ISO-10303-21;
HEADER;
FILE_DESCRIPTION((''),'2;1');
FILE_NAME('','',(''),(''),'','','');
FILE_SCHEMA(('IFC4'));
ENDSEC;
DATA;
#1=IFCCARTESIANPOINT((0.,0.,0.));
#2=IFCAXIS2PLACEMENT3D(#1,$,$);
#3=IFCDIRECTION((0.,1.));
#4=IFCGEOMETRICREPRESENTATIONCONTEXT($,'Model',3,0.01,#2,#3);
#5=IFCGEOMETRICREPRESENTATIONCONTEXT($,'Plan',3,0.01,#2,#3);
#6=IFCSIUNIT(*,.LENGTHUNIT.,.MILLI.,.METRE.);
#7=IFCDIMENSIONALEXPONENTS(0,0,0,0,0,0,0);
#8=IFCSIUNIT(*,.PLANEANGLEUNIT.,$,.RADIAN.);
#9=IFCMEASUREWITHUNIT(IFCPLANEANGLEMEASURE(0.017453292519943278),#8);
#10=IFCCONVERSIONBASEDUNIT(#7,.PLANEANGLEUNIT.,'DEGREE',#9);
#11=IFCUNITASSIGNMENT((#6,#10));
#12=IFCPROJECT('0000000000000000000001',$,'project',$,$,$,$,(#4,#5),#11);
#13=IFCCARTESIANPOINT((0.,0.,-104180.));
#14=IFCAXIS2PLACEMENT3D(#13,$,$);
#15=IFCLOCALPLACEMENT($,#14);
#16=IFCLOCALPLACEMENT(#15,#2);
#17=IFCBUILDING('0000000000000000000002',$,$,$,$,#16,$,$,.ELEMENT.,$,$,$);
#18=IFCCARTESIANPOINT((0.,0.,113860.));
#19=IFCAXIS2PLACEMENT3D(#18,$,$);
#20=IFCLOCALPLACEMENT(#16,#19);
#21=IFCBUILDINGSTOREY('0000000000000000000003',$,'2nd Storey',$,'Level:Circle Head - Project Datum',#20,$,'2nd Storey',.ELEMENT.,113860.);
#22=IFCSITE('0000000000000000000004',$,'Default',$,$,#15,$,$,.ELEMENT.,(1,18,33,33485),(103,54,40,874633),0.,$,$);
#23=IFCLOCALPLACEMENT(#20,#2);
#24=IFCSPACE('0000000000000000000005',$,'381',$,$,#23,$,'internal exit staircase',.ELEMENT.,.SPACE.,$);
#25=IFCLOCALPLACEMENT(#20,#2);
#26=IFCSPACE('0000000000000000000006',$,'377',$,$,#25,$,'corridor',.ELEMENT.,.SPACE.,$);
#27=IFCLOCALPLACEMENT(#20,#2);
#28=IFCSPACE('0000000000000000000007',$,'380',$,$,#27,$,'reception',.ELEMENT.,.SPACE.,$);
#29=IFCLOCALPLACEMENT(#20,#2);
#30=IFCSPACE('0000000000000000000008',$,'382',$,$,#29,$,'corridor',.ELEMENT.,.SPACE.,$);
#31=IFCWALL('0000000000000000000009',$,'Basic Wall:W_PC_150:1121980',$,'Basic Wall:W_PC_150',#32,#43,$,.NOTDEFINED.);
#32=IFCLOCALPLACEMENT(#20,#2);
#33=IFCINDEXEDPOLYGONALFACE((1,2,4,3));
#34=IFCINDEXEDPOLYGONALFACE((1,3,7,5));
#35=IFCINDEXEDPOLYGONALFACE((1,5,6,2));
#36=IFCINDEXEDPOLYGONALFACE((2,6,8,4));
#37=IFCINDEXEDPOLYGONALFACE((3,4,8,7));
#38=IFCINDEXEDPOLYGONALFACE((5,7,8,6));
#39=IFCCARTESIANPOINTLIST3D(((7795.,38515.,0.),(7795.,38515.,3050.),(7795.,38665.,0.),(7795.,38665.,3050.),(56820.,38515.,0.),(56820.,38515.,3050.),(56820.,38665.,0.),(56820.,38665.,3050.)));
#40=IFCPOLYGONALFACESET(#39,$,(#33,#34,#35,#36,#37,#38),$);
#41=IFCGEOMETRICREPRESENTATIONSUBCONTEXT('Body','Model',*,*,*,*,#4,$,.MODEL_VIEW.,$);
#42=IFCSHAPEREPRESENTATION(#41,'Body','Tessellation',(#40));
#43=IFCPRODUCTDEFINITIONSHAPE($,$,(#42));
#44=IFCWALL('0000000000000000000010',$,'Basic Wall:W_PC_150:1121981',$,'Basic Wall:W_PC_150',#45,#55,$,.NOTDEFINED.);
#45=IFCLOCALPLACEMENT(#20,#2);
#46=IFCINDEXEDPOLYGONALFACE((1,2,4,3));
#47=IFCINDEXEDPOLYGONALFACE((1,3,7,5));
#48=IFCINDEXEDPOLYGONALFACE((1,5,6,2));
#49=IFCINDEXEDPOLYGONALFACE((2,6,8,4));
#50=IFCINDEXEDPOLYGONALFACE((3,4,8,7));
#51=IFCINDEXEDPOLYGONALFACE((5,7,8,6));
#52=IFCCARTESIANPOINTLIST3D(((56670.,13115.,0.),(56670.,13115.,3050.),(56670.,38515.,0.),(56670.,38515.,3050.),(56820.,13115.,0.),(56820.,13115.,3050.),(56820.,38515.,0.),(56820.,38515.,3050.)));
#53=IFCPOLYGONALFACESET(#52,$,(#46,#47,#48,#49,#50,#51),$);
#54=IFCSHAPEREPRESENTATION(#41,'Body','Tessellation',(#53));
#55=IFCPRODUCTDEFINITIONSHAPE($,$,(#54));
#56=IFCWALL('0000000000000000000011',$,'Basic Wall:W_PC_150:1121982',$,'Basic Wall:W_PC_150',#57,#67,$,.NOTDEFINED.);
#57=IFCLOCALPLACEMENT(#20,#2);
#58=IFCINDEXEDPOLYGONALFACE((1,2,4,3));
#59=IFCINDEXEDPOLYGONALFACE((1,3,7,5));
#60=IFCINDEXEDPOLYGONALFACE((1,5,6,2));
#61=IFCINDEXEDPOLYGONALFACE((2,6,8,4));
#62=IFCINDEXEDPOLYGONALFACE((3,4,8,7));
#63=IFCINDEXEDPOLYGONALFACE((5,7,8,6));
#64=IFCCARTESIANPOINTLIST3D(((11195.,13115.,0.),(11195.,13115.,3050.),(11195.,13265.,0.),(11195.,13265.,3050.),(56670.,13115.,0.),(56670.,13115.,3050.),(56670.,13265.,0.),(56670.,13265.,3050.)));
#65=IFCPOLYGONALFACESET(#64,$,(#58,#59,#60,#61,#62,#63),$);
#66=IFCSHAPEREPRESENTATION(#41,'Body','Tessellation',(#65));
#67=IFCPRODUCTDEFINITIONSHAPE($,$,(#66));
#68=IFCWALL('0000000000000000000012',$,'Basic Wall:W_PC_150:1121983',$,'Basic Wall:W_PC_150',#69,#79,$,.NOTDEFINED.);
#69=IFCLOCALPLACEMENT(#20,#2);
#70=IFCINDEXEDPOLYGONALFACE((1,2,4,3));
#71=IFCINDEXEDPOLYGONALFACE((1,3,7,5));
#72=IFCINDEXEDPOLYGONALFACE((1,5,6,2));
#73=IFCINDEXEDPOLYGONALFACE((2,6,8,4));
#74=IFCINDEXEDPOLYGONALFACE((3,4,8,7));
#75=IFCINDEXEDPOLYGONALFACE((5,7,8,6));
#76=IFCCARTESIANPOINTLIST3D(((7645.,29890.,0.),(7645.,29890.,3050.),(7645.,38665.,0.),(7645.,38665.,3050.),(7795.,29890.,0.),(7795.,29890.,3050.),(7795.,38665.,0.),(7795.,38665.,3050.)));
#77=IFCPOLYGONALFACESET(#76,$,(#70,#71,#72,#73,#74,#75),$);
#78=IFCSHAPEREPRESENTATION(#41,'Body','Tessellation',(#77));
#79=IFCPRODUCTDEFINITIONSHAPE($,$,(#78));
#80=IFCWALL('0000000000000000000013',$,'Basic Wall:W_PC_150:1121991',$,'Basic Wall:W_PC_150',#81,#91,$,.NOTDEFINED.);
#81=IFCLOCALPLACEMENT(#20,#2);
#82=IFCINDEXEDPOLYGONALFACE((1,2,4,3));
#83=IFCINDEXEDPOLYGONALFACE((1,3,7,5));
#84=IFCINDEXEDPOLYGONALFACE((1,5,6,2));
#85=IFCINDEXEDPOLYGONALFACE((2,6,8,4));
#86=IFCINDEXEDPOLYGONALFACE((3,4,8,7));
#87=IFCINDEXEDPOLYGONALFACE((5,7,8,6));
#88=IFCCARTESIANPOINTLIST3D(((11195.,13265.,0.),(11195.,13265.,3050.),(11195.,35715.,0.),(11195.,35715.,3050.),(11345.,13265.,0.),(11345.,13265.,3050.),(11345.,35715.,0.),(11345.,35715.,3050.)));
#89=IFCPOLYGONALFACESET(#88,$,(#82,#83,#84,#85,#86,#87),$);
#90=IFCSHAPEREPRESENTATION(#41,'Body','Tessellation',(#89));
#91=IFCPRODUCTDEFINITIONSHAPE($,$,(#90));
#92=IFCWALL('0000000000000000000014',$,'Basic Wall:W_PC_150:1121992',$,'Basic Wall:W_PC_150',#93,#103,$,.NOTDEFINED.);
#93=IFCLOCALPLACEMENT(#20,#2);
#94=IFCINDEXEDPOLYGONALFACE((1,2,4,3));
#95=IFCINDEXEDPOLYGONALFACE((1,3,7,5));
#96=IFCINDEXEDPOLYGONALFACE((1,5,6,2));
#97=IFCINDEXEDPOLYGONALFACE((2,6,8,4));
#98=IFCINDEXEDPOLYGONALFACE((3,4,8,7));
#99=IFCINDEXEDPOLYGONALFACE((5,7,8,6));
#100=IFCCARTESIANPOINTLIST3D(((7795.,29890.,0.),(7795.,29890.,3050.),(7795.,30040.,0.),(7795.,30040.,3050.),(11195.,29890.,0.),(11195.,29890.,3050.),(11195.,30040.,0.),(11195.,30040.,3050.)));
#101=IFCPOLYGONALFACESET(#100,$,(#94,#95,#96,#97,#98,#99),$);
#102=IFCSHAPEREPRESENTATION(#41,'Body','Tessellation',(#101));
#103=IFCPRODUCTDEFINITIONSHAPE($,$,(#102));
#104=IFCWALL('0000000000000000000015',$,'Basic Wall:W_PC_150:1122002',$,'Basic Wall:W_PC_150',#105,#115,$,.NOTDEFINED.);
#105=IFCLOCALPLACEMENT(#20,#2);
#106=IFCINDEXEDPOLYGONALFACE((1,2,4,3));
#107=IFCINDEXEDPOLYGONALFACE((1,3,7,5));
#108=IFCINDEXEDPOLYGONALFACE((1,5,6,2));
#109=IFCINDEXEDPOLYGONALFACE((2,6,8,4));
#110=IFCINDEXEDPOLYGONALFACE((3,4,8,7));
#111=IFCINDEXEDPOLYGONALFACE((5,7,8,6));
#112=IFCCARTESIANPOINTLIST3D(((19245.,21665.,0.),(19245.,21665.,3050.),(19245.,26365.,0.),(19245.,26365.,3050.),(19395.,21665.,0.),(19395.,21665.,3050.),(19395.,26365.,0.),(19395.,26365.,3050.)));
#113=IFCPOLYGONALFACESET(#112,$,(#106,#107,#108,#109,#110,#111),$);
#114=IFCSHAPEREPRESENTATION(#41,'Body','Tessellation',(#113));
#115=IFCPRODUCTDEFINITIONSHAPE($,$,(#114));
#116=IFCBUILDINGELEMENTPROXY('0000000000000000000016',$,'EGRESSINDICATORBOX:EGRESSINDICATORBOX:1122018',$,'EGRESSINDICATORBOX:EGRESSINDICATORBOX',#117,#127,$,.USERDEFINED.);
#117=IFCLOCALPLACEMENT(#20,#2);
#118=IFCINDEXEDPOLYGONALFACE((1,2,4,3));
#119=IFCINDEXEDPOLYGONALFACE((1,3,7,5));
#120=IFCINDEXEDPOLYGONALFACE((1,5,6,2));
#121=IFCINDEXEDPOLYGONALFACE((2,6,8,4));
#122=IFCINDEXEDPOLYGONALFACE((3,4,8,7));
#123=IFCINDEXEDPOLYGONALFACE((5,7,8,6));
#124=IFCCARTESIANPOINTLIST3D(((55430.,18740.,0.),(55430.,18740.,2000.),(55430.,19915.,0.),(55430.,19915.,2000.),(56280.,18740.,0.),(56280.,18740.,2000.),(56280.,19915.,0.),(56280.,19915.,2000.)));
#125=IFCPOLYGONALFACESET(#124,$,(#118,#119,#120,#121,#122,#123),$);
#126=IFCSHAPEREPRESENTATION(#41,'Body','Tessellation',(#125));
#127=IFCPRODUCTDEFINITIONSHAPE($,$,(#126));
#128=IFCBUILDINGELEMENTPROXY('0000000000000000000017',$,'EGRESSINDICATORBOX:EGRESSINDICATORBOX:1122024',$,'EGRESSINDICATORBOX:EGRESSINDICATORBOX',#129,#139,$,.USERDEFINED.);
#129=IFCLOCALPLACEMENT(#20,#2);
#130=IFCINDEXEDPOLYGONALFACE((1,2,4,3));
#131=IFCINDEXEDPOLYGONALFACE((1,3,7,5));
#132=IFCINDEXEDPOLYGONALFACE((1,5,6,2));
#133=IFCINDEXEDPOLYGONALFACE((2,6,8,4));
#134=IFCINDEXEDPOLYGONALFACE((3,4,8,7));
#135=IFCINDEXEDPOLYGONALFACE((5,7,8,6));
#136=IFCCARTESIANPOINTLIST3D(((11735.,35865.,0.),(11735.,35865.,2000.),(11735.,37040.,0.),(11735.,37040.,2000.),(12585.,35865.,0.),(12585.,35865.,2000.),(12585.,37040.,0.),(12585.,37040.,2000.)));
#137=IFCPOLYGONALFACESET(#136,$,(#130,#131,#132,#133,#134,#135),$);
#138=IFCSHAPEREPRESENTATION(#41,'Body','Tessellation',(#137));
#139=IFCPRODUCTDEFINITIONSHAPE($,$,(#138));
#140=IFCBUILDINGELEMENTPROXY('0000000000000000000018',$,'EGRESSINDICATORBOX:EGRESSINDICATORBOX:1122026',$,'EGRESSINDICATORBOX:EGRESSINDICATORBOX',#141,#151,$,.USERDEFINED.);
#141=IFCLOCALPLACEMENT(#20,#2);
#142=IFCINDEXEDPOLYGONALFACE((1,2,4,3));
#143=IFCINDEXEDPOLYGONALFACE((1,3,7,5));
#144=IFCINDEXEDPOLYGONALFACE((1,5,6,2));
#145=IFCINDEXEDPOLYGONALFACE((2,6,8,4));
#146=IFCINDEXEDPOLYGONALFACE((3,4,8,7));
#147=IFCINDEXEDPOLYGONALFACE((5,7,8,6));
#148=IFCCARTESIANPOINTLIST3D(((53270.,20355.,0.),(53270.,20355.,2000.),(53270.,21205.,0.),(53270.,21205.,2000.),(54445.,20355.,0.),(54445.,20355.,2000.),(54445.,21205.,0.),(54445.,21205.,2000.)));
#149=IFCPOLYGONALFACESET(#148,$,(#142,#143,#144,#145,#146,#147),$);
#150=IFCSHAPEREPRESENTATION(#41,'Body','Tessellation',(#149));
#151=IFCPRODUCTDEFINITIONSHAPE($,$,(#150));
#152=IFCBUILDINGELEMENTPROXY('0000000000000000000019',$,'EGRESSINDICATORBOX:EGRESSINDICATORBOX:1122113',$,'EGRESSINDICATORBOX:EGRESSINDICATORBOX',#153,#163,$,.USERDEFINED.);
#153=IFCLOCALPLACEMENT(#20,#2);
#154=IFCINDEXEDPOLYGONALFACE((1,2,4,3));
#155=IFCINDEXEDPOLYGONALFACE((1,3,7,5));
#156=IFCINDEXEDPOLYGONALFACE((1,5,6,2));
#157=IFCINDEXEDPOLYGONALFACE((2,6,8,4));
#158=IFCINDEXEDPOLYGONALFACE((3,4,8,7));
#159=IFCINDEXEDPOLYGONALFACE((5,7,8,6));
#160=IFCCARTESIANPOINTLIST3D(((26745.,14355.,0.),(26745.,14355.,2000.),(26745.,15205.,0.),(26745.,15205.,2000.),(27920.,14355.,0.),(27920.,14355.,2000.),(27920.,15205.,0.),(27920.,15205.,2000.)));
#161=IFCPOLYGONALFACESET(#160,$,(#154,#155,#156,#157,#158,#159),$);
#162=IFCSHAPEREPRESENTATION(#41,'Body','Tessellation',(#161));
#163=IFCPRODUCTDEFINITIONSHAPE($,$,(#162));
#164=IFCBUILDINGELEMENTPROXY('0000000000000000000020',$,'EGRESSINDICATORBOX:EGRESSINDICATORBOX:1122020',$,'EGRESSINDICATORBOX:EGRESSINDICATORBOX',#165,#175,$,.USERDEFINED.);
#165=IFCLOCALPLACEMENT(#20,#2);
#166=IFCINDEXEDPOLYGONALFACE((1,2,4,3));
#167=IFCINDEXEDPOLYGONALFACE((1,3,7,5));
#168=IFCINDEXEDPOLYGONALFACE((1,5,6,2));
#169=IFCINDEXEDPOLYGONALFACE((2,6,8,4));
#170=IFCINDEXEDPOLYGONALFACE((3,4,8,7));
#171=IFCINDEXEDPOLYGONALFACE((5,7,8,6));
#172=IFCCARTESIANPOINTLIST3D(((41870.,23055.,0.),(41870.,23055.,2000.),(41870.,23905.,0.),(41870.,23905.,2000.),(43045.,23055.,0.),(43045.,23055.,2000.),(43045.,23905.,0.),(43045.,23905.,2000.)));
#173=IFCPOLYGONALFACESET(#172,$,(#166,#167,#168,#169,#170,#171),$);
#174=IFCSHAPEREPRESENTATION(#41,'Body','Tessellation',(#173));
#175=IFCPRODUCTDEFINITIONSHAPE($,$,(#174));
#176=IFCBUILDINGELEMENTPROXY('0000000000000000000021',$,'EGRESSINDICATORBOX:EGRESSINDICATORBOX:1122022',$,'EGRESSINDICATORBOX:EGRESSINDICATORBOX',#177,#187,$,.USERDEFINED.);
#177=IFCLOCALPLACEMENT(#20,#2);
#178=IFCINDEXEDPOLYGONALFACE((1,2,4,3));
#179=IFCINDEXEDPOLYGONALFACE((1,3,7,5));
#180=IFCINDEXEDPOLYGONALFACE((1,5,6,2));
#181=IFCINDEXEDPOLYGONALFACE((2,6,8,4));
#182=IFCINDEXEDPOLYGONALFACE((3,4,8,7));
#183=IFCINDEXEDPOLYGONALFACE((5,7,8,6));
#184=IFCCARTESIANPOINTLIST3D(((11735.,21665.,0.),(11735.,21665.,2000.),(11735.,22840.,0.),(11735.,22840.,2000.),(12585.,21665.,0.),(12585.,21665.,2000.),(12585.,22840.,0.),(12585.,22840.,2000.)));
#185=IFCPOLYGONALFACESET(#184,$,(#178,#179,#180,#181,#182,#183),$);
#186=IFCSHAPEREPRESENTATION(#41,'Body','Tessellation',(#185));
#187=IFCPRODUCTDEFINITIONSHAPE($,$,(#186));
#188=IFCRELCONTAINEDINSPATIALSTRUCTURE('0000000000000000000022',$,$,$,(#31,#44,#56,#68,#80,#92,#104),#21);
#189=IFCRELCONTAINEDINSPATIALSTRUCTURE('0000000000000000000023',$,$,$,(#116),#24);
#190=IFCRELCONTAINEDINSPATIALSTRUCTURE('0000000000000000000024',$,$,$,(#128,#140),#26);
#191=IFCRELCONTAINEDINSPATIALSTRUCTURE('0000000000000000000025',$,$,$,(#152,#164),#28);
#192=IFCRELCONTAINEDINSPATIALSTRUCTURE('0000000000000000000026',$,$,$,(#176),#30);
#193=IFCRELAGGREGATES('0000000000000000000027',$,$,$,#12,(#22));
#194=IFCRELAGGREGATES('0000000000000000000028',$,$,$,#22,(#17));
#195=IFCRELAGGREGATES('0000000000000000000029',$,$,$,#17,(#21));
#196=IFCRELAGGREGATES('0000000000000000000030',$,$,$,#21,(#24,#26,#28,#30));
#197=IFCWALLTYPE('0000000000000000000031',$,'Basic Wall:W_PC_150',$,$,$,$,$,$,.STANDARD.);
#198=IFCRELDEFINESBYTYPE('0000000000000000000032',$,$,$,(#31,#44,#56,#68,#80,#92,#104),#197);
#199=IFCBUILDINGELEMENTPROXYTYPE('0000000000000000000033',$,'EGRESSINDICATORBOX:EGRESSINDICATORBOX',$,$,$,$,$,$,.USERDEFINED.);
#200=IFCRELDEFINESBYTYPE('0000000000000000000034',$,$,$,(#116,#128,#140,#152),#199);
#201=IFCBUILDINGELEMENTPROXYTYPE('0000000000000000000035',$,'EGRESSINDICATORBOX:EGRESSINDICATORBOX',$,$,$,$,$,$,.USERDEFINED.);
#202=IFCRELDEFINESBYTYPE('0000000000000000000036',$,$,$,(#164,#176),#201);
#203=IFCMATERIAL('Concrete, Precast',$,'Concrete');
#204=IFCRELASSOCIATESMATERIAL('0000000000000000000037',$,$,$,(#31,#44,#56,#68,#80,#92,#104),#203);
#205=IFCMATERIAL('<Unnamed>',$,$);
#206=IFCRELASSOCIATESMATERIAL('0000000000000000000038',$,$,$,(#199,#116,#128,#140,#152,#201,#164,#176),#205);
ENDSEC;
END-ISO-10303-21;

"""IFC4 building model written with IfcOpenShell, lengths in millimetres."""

from ifc_helpers import new_model, entity, si_unit, converted_unit, direction, frame, origin, place, context, subcontext, project, spatial, indexed_curve, outline, extrude, source, transform, mapped, material, type_object, type_shapes, element, save


model = new_model("IFC4")

# Units and contexts
model_context = context("Model", 3, precision=0.01, world=origin(), true_north=direction((0.0, 1.0)))
plan_context = context("Plan", 3, precision=0.01, world=origin(), true_north=direction((0.0, 1.0)))
body_context = subcontext(model_context, "Body", "Model", "MODEL_VIEW")
ifc_project = project(units=[si_unit("LENGTHUNIT", "METRE", prefix="MILLI"), converted_unit("PLANEANGLEUNIT", "DEGREE", entity("IfcPlaneAngleMeasure", 0.017453292519943278), si_unit("PLANEANGLEUNIT", "RADIAN"), dimensions=[0, 0, 0, 0, 0, 0, 0])], contexts=[model_context, plan_context])

# Site, building, storey
site_placement = place(None, frame((0.0, 0.0, -104180.0)))
site = spatial("IfcSite", under=ifc_project, at=site_placement, Name="Default", CompositionType="ELEMENT", RefLatitude=(1, 18, 33, 33485), RefLongitude=(103, 54, 40, 874633), RefElevation=0.0)
building_placement = place(site_placement, origin())
building = spatial("IfcBuilding", under=site, at=building_placement, CompositionType="ELEMENT")
storey_placement = place(building_placement, frame((0.0, 0.0, 113860.0)))
storey = spatial("IfcBuildingStorey", under=building, at=storey_placement, Name="2nd Storey", ObjectType="Level:Circle Head - Project Datum", LongName="2nd Storey", CompositionType="ELEMENT", Elevation=113860.0)

# Shared definitions
ifc_material_1 = material(Name="Concrete, Precast", Category="Concrete")

# Walls
wall_type = type_object("IfcWallType", Name="Basic Wall:W_PC_150", PredefinedType="STANDARD")
wall_1_placement = place(storey_placement, frame((56820.0, 38590.0, 0.0), z_axis=(0.0, 0.0, 1.0), x_axis=(-1.0, 0.0, 0.0)))
element("IfcWall", 1, at=wall_1_placement, inside=storey, type_object=wall_type, material=ifc_material_1, Name="Basic Wall:W_PC_150:1121980", ObjectType="Basic Wall:W_PC_150", PredefinedType="NOTDEFINED", context=body_context, shape_type="SweptSolid", body=[
    extrude(outline(indexed_curve([(49025.0, 75.0), (0.0, 75.0), (0.0, -75.0), (49025.0, -75.0), (49025.0, 75.0)], self_intersect=False)), origin(), (0.0, 0.0, 1.0), 3050.0),
])
wall_2_placement = place(storey_placement, frame((56745.0, 13115.0, 0.0), z_axis=(0.0, 0.0, 1.0), x_axis=(0.0, 1.0, 0.0)))
element("IfcWall", 2, at=wall_2_placement, inside=storey, type_object=wall_type, material=ifc_material_1, Name="Basic Wall:W_PC_150:1121981", ObjectType="Basic Wall:W_PC_150", PredefinedType="NOTDEFINED", context=body_context, shape_type="SweptSolid", body=[
    extrude(outline(indexed_curve([(25400.0, 75.0), (0.0, 75.0), (0.0, -75.0), (25400.0, -75.0), (25400.0, 75.0)], self_intersect=False)), origin(), (0.0, 0.0, 1.0), 3050.0),
])
wall_3_placement = place(storey_placement, frame((11195.0, 13190.0, 0.0)))
element("IfcWall", 3, at=wall_3_placement, inside=storey, type_object=wall_type, material=ifc_material_1, Name="Basic Wall:W_PC_150:1121982", ObjectType="Basic Wall:W_PC_150", PredefinedType="NOTDEFINED", context=body_context, shape_type="SweptSolid", body=[
    extrude(outline(indexed_curve([(45475.0, 75.0), (0.0, 75.0), (0.0, -75.0), (45475.0, -75.0), (45475.0, 75.0)], self_intersect=False)), origin(), (0.0, 0.0, 1.0), 3050.0),
])
wall_4_placement = place(storey_placement, frame((7720.0, 38665.0, 0.0), z_axis=(0.0, 0.0, 1.0), x_axis=(0.0, -1.0, 0.0)))
element("IfcWall", 4, at=wall_4_placement, inside=storey, type_object=wall_type, material=ifc_material_1, Name="Basic Wall:W_PC_150:1121983", ObjectType="Basic Wall:W_PC_150", PredefinedType="NOTDEFINED", context=body_context, shape_type="SweptSolid", body=[
    extrude(outline(indexed_curve([(8775.0, 75.0), (0.0, 75.0), (0.0, -75.0), (8775.0, -75.0), (8775.0, 75.0)], self_intersect=False)), origin(), (0.0, 0.0, 1.0), 3050.0),
])
wall_5_placement = place(storey_placement, frame((11270.0, 35715.0, 0.0), z_axis=(0.0, 0.0, 1.0), x_axis=(0.0, -1.0, 0.0)))
element("IfcWall", 5, at=wall_5_placement, inside=storey, type_object=wall_type, material=ifc_material_1, Name="Basic Wall:W_PC_150:1121991", ObjectType="Basic Wall:W_PC_150", PredefinedType="NOTDEFINED", context=body_context, shape_type="SweptSolid", body=[
    extrude(outline(indexed_curve([(22450.0, 75.0), (0.0, 75.0), (0.0, -75.0), (22450.0, -75.0), (22450.0, 75.0)], self_intersect=False)), origin(), (0.0, 0.0, 1.0), 3050.0),
])
wall_6_placement = place(storey_placement, frame((7795.0, 29965.0, 0.0)))
element("IfcWall", 6, at=wall_6_placement, inside=storey, type_object=wall_type, material=ifc_material_1, Name="Basic Wall:W_PC_150:1121992", ObjectType="Basic Wall:W_PC_150", PredefinedType="NOTDEFINED", context=body_context, shape_type="SweptSolid", body=[
    extrude(outline(indexed_curve([(3400.0, 75.0), (0.0, 75.0), (0.0, -75.0), (3400.0, -75.0), (3400.0, 75.0)], self_intersect=False)), origin(), (0.0, 0.0, 1.0), 3050.0),
])
wall_7_placement = place(storey_placement, frame((19320.0, 21665.0, 0.0), z_axis=(0.0, 0.0, 1.0), x_axis=(0.0, 1.0, 0.0)))
element("IfcWall", 7, at=wall_7_placement, inside=storey, type_object=wall_type, material=ifc_material_1, Name="Basic Wall:W_PC_150:1122002", ObjectType="Basic Wall:W_PC_150", PredefinedType="NOTDEFINED", context=body_context, shape_type="SweptSolid", body=[
    extrude(outline(indexed_curve([(4700.0, 75.0), (0.0, 75.0), (0.0, -75.0), (4700.0, -75.0), (4700.0, 75.0)], self_intersect=False)), origin(), (0.0, 0.0, 1.0), 3050.0),
])

# Shared definitions
space_1_placement = place(storey_placement, origin())
space_1 = spatial("IfcSpace", under=storey, at=space_1_placement, Name="381", LongName="internal exit staircase", CompositionType="ELEMENT", PredefinedType="SPACE")

# Building element proxy
ifc_material_2 = material(Name="<Unnamed>")
building_element_proxy_type_1 = type_object("IfcBuildingElementProxyType", Name="EGRESSINDICATORBOX:EGRESSINDICATORBOX", PredefinedType="USERDEFINED", material=ifc_material_2)
shared_shape_1 = source(origin(), body_context, "Body", "SweptSolid", [
    extrude(outline(indexed_curve([(-587.5, -425.0), (587.5, -425.0), (587.5, 425.0), (-587.5, 425.0), (-587.5, -425.0)], self_intersect=False)), frame((0.0, 0.0, 0.0), z_axis=(0.0, 0.0, 1.0), x_axis=(0.0, 1.0, 0.0)), (0.0, 0.0, 1.0), 2000.0),
])
type_shapes(building_element_proxy_type_1, [shared_shape_1])
proxy_1_placement = place(space_1_placement, frame((55855.0, 19327.5, 0.0)))
element("IfcBuildingElementProxy", 8, at=proxy_1_placement, inside=space_1, type_object=building_element_proxy_type_1, material=ifc_material_2, Name="EGRESSINDICATORBOX:EGRESSINDICATORBOX:1122018", ObjectType="EGRESSINDICATORBOX:EGRESSINDICATORBOX", PredefinedType="USERDEFINED", context=body_context, shape_type="MappedRepresentation", body=[
    mapped(shared_shape_1, transform((0.0, 0.0, 0.0), scale=1.0)),
])

# Shared definitions
space_2_placement = place(storey_placement, origin())
space_2 = spatial("IfcSpace", under=storey, at=space_2_placement, Name="377", LongName="corridor", CompositionType="ELEMENT", PredefinedType="SPACE")

# Building element proxies
for number, where, z_axis, x_axis, name in (
    (9, (12160.0, 36452.5, 0.0), (0.0, 0.0, 1.0), (-1.0, 0.0, 0.0), "EGRESSINDICATORBOX:EGRESSINDICATORBOX:1122024"),
    (10, (53857.5, 20780.0, 0.0), (0.0, 0.0, 1.0), (0.0, 1.0, 0.0), "EGRESSINDICATORBOX:EGRESSINDICATORBOX:1122026"),
):
    element("IfcBuildingElementProxy", number, at=place(space_2_placement, frame(where, z_axis=z_axis, x_axis=x_axis)), inside=space_2, type_object=building_element_proxy_type_1, material=ifc_material_2, Name=name, ObjectType="EGRESSINDICATORBOX:EGRESSINDICATORBOX", PredefinedType="USERDEFINED", context=body_context, shape_type="MappedRepresentation", body=[
        mapped(shared_shape_1, transform((0.0, 0.0, 0.0), scale=1.0)),
    ])

# Shared definitions
space_3_placement = place(storey_placement, origin())
space_3 = spatial("IfcSpace", under=storey, at=space_3_placement, Name="380", LongName="reception", CompositionType="ELEMENT", PredefinedType="SPACE")

# Building element proxies
proxy_2_placement = place(space_3_placement, frame((27332.5, 14780.0, 0.0), z_axis=(0.0, 0.0, 1.0), x_axis=(0.0, 1.0, 0.0)))
element("IfcBuildingElementProxy", 11, at=proxy_2_placement, inside=space_3, type_object=building_element_proxy_type_1, material=ifc_material_2, Name="EGRESSINDICATORBOX:EGRESSINDICATORBOX:1122113", ObjectType="EGRESSINDICATORBOX:EGRESSINDICATORBOX", PredefinedType="USERDEFINED", context=body_context, shape_type="MappedRepresentation", body=[
    mapped(shared_shape_1, transform((0.0, 0.0, 0.0), scale=1.0)),
])
building_element_proxy_type_2 = type_object("IfcBuildingElementProxyType", Name="EGRESSINDICATORBOX:EGRESSINDICATORBOX", PredefinedType="USERDEFINED", material=ifc_material_2)
shared_shape_2 = source(origin(), body_context, "Body", "SweptSolid", [
    extrude(outline(indexed_curve([(-425.0, -587.5), (425.0, -587.5), (425.0, 587.5), (-425.0, 587.5), (-425.0, -587.5)], self_intersect=False)), frame((0.0, 0.0, 0.0), z_axis=(0.0, 0.0, 1.0), x_axis=(-1.0, 0.0, 0.0)), (0.0, 0.0, 1.0), 2000.0),
])
type_shapes(building_element_proxy_type_2, [shared_shape_2])
proxy_3_placement = place(space_3_placement, frame((42457.5, 23480.0, 0.0), z_axis=(0.0, 0.0, 1.0), x_axis=(0.0, -1.0, 0.0)))
element("IfcBuildingElementProxy", 12, at=proxy_3_placement, inside=space_3, type_object=building_element_proxy_type_2, material=ifc_material_2, Name="EGRESSINDICATORBOX:EGRESSINDICATORBOX:1122020", ObjectType="EGRESSINDICATORBOX:EGRESSINDICATORBOX", PredefinedType="USERDEFINED", context=body_context, shape_type="MappedRepresentation", body=[
    mapped(shared_shape_2, transform((0.0, 0.0, 0.0), scale=1.0)),
])

# Shared definitions
space_4_placement = place(storey_placement, origin())
space_4 = spatial("IfcSpace", under=storey, at=space_4_placement, Name="382", LongName="corridor", CompositionType="ELEMENT", PredefinedType="SPACE")

# Building element proxy
proxy_4_placement = place(space_4_placement, frame((12160.0, 22252.5, 0.0)))
element("IfcBuildingElementProxy", 13, at=proxy_4_placement, inside=space_4, type_object=building_element_proxy_type_2, material=ifc_material_2, Name="EGRESSINDICATORBOX:EGRESSINDICATORBOX:1122022", ObjectType="EGRESSINDICATORBOX:EGRESSINDICATORBOX", PredefinedType="USERDEFINED", context=body_context, shape_type="MappedRepresentation", body=[
    mapped(shared_shape_2, transform((0.0, 0.0, 0.0), scale=1.0)),
])

save(model, "model.ifc")
